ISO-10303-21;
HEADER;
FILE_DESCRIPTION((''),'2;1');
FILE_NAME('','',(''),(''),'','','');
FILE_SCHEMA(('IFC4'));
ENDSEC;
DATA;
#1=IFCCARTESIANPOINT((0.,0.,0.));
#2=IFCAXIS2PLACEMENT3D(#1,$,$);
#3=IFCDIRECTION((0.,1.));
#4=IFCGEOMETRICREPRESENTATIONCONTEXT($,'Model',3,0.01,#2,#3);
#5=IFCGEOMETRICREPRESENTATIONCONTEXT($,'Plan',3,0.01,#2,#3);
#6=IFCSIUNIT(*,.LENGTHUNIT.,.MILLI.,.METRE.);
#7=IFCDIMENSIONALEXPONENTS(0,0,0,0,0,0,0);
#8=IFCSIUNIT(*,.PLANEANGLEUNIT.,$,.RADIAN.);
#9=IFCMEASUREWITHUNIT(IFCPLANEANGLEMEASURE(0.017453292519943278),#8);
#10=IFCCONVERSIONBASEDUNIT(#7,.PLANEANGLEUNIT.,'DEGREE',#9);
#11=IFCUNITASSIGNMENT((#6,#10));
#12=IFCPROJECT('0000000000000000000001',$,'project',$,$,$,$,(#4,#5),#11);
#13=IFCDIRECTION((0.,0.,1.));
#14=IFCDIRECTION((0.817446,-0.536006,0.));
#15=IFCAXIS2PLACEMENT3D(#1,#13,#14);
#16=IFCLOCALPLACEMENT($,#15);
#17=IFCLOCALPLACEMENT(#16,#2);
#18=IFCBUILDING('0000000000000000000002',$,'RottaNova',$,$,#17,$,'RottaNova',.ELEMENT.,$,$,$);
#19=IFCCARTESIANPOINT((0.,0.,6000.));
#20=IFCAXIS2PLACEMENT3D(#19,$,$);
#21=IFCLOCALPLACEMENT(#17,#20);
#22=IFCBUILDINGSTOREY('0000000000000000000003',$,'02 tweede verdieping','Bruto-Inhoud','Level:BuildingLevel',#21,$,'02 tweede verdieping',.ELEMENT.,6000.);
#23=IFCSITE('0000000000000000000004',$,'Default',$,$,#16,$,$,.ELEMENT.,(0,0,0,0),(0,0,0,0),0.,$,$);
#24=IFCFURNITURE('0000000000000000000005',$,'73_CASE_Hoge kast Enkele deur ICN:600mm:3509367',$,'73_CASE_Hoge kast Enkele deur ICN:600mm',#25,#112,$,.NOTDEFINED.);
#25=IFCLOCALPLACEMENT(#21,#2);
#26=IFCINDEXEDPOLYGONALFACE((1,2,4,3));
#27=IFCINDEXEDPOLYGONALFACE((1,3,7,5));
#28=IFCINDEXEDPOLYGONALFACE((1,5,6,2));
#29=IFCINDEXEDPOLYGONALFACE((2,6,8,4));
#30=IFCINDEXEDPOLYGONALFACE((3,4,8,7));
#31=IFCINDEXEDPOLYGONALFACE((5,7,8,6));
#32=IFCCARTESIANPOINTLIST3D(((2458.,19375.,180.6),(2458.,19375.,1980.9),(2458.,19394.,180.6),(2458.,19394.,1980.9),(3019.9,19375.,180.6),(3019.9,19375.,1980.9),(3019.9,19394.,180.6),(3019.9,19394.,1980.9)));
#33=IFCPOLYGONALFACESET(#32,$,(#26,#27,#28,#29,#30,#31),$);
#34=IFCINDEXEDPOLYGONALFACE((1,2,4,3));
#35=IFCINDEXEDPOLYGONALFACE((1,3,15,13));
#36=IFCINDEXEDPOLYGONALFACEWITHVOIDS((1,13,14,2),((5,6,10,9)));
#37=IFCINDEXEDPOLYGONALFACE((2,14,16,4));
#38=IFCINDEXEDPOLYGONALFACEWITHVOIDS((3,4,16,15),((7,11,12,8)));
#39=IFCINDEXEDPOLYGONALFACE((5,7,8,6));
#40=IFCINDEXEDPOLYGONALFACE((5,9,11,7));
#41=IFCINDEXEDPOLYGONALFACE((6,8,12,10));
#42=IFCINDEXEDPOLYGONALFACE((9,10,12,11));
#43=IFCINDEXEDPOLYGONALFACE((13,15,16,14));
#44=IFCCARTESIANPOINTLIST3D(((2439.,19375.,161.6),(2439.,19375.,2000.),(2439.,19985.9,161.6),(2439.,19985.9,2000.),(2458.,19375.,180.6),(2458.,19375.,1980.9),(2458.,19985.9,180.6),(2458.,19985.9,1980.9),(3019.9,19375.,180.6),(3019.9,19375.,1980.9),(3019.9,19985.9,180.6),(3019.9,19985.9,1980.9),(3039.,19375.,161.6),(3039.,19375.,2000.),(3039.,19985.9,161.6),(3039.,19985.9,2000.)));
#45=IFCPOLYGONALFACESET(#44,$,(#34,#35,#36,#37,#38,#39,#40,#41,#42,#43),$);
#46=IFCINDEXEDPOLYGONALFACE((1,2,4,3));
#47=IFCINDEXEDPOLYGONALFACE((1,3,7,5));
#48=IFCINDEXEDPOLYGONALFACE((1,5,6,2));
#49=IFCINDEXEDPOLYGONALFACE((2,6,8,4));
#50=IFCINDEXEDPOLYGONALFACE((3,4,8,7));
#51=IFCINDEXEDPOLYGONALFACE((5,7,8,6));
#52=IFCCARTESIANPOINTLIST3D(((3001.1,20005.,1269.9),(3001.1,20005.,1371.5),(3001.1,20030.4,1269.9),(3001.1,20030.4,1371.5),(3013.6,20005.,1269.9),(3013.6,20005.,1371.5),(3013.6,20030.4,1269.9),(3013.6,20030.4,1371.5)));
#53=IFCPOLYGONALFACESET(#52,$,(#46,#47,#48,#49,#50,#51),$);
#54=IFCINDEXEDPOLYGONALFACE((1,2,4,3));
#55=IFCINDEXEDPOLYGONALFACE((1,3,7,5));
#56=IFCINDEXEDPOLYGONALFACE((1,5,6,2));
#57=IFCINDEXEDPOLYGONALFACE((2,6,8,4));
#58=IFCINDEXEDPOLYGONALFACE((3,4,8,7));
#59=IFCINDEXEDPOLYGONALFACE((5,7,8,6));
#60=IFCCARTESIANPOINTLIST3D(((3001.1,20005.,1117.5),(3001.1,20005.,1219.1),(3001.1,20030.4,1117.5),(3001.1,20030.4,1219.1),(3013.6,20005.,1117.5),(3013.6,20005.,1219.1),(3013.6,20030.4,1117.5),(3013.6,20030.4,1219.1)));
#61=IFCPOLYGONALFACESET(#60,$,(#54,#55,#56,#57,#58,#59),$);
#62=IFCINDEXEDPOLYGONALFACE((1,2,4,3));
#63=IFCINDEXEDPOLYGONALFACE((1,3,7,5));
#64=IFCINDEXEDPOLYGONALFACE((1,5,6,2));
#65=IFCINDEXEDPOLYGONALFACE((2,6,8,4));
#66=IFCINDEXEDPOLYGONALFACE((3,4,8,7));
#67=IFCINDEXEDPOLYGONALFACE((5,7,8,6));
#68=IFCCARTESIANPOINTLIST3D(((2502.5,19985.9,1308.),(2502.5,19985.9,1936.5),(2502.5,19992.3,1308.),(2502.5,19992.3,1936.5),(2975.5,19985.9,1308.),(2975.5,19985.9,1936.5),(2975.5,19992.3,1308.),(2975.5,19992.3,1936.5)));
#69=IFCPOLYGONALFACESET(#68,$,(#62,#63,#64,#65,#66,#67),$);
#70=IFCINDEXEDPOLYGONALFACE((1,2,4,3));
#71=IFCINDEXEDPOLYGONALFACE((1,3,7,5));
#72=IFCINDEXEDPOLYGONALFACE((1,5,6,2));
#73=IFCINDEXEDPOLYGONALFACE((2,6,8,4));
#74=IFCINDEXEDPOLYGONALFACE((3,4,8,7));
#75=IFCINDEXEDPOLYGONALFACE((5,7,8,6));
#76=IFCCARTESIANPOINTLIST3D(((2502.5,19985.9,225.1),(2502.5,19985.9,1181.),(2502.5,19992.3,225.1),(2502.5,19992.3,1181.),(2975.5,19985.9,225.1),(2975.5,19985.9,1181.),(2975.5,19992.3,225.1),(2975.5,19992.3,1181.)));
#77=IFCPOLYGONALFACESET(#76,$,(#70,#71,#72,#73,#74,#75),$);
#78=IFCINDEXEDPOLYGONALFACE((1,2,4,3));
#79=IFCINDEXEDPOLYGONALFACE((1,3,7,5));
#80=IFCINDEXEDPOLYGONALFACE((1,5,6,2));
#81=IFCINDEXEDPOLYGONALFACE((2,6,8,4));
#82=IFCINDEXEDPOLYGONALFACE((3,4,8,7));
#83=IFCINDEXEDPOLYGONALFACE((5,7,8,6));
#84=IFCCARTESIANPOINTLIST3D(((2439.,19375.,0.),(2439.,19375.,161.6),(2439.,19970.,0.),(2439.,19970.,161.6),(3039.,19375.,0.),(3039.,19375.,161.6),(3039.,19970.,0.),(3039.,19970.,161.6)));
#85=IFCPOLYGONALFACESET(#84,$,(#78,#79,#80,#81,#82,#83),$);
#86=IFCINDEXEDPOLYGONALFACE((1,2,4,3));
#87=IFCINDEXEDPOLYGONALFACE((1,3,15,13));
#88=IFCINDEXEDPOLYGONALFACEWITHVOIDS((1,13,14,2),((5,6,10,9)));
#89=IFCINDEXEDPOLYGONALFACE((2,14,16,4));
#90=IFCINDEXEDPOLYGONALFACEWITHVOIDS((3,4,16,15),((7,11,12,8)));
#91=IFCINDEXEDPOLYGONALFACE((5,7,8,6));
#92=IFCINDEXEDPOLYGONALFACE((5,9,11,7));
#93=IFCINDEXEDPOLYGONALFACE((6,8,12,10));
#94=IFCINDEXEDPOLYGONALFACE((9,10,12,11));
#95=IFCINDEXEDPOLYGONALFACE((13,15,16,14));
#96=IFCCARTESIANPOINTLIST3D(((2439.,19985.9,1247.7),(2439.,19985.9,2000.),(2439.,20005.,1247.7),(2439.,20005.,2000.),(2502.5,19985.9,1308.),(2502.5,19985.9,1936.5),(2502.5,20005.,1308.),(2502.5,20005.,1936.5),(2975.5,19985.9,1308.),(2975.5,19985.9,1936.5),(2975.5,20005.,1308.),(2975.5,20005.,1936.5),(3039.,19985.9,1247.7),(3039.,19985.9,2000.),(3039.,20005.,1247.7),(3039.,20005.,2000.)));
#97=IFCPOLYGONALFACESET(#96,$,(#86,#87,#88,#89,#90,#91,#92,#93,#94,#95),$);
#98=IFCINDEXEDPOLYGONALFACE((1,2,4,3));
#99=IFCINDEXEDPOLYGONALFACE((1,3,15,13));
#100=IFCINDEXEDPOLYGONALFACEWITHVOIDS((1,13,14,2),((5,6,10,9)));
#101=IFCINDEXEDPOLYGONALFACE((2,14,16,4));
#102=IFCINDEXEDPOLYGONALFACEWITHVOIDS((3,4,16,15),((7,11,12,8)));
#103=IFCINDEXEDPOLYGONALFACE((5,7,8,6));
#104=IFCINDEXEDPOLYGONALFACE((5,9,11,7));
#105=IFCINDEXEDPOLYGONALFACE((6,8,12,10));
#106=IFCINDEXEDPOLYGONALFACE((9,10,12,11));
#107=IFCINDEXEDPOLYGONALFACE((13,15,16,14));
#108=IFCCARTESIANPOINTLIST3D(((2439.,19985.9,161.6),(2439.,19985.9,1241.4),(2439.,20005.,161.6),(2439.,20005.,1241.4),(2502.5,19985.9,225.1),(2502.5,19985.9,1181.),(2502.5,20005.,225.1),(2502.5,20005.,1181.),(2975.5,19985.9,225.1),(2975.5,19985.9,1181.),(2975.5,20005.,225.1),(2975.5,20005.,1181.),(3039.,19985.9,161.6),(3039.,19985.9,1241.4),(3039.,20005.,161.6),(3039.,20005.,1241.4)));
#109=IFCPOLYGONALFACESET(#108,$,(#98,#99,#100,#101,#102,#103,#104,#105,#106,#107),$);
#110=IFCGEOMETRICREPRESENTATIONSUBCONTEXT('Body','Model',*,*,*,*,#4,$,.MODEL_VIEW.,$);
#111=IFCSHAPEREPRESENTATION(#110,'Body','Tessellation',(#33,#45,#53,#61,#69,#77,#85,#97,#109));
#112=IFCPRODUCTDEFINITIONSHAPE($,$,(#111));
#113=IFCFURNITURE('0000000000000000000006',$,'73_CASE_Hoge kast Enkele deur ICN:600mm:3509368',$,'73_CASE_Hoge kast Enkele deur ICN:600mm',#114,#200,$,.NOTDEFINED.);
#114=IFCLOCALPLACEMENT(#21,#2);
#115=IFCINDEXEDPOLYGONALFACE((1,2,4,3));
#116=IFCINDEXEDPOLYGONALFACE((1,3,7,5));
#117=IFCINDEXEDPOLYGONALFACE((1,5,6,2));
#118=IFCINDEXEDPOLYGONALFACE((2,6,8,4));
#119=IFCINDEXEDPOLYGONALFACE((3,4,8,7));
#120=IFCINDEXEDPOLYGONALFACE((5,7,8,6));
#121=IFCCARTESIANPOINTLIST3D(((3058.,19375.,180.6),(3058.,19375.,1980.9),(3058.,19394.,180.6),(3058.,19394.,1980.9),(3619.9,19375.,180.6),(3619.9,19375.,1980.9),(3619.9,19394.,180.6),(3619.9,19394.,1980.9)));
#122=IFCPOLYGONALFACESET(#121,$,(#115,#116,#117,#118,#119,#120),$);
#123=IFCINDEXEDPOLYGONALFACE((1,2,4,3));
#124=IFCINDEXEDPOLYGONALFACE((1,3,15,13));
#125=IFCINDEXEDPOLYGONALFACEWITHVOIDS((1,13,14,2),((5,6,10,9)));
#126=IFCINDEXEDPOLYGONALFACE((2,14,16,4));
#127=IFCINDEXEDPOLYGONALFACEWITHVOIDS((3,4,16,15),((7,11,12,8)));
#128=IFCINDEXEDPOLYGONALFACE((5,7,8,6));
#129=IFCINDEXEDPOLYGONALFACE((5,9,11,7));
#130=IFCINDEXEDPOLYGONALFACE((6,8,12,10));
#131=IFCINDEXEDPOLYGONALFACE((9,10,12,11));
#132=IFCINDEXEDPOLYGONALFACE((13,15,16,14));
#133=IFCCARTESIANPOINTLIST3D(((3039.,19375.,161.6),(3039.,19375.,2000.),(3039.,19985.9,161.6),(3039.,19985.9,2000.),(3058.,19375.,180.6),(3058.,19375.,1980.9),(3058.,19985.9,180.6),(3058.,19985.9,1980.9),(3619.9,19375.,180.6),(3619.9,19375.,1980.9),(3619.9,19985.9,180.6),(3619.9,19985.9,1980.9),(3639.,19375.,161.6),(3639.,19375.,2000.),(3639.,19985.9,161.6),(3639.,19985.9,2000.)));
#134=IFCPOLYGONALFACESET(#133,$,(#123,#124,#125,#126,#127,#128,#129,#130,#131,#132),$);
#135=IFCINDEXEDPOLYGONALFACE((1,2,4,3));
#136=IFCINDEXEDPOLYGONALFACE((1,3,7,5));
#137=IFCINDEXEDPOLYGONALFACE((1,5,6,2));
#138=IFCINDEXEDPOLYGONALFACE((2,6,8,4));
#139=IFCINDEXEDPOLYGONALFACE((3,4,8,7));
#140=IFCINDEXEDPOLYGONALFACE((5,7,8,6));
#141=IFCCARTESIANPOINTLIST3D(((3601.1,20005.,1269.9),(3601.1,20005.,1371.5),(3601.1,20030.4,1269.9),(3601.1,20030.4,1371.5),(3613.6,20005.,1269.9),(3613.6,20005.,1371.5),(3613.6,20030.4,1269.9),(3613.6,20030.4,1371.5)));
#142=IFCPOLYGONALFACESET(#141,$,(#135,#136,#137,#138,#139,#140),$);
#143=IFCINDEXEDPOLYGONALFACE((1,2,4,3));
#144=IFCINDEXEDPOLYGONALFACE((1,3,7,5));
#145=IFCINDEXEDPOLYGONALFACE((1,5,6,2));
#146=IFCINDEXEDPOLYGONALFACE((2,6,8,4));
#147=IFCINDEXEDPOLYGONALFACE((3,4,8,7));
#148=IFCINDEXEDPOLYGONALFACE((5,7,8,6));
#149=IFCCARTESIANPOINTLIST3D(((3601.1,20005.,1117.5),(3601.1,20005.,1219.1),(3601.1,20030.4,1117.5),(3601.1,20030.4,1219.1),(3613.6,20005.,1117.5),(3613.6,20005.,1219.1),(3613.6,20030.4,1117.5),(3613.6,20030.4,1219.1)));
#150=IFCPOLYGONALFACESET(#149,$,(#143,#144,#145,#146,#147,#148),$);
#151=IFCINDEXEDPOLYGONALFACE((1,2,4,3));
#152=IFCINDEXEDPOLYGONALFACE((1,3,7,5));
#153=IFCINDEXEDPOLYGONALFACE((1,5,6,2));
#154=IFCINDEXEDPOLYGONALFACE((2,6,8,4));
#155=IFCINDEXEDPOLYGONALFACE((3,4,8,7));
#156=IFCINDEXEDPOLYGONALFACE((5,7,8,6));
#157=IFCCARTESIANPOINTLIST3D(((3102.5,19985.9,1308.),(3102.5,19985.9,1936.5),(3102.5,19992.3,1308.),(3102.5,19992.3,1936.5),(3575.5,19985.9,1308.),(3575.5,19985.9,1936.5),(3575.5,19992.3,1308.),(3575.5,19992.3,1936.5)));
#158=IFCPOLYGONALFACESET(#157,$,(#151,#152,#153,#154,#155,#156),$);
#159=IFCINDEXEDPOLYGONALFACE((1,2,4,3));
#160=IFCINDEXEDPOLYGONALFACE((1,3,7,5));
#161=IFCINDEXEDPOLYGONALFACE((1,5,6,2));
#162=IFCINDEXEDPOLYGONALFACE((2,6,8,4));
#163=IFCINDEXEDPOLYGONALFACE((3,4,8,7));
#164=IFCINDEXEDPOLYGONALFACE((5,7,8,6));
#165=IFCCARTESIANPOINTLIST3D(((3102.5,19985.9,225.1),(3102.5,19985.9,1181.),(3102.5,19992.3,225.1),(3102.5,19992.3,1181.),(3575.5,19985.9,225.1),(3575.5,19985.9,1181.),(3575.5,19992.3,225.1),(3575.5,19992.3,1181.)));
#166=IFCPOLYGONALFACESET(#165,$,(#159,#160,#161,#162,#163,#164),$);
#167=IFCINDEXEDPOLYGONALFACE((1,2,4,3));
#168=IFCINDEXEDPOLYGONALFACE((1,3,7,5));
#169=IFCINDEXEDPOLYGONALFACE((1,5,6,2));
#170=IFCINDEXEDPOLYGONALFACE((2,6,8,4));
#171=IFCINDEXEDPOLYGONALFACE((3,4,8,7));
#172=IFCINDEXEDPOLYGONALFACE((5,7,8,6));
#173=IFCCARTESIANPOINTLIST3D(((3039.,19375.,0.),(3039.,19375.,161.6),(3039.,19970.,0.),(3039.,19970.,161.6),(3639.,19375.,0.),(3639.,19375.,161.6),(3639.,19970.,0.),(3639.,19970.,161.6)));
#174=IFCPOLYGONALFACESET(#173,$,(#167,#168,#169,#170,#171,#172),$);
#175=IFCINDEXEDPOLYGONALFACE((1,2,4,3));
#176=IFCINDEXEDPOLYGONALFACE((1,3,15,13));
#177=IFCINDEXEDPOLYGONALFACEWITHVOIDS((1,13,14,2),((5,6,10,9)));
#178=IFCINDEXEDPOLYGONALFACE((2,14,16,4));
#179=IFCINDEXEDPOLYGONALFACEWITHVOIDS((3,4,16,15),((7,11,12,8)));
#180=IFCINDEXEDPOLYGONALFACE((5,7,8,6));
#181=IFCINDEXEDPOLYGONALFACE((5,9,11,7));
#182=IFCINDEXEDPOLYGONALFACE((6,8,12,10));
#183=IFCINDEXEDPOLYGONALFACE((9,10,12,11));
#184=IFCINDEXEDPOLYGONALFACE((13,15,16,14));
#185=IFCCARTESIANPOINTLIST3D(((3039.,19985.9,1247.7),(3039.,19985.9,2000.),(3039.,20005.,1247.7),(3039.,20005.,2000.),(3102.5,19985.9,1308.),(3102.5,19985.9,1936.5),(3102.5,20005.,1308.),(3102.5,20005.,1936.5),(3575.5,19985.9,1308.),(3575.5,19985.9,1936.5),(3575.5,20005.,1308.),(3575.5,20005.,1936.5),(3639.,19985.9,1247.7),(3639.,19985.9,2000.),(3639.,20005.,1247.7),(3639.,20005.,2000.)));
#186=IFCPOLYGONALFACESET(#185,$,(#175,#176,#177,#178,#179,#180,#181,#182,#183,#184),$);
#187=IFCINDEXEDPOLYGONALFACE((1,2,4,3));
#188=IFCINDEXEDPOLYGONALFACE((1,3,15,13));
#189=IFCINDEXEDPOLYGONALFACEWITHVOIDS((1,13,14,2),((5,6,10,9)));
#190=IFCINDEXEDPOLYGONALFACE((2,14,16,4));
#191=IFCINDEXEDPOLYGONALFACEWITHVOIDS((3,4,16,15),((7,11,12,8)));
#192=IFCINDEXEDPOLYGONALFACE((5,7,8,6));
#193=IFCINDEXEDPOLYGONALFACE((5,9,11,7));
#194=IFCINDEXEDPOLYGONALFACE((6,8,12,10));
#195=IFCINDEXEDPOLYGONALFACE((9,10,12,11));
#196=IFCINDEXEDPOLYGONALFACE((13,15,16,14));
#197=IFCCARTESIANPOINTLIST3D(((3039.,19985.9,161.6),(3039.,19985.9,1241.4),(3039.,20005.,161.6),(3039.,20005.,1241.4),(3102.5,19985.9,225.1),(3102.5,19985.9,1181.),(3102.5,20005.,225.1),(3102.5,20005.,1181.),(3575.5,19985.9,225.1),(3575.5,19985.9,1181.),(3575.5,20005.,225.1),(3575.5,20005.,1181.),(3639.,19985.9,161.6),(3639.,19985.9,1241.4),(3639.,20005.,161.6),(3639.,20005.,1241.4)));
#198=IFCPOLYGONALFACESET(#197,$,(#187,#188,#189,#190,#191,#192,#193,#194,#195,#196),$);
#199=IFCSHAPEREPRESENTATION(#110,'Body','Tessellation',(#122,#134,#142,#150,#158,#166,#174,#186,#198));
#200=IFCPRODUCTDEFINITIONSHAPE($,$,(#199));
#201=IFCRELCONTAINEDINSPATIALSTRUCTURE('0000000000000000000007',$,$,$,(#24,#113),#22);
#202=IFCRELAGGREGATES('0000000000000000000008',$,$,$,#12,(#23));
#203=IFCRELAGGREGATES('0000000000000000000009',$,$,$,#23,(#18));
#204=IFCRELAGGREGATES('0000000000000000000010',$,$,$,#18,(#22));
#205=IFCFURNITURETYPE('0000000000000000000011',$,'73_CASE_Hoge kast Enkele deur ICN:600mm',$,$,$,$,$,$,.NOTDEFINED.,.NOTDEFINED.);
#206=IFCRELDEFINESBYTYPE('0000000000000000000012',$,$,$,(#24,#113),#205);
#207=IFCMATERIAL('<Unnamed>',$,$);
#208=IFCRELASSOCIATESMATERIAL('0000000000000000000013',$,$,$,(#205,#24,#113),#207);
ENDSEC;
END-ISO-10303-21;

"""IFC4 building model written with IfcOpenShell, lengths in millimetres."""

from ifc_helpers import new_model, entity, si_unit, converted_unit, direction, frame, origin, place, context, subcontext, project, spatial, indexed_curve, outline, extrude, source, transform, mapped, material, type_object, type_shapes, element, save


model = new_model("IFC4")

# Units and contexts
model_context = context("Model", 3, precision=0.01, world=origin(), true_north=direction((0.0, 1.0)))
plan_context = context("Plan", 3, precision=0.01, world=origin(), true_north=direction((0.0, 1.0)))
body_context = subcontext(model_context, "Body", "Model", "MODEL_VIEW")
ifc_project = project(units=[si_unit("LENGTHUNIT", "METRE", prefix="MILLI"), converted_unit("PLANEANGLEUNIT", "DEGREE", entity("IfcPlaneAngleMeasure", 0.017453292519943278), si_unit("PLANEANGLEUNIT", "RADIAN"), dimensions=[0, 0, 0, 0, 0, 0, 0])], contexts=[model_context, plan_context])

# Site, building, storey
site_placement = place(None, frame((0.0, 0.0, 0.0), z_axis=(0.0, 0.0, 1.0), x_axis=(0.817446, -0.536006, 0.0)))
site = spatial("IfcSite", under=ifc_project, at=site_placement, Name="Default", CompositionType="ELEMENT", RefLatitude=(0, 0, 0, 0), RefLongitude=(0, 0, 0, 0), RefElevation=0.0)
building_placement = place(site_placement, origin())
building = spatial("IfcBuilding", under=site, at=building_placement, Name="RottaNova", LongName="RottaNova", CompositionType="ELEMENT")
storey_placement = place(building_placement, frame((0.0, 0.0, 6000.0)))
storey = spatial("IfcBuildingStorey", under=building, at=storey_placement, Name="02 tweede verdieping", Description="Bruto-Inhoud", ObjectType="Level:BuildingLevel", LongName="02 tweede verdieping", CompositionType="ELEMENT", Elevation=6000.0)

# Furniture
ifc_material_1 = material(Name="<Unnamed>")
furniture_type = type_object("IfcFurnitureType", Name="73_CASE_Hoge kast Enkele deur ICN:600mm", AssemblyPlace="NOTDEFINED", PredefinedType="NOTDEFINED", material=ifc_material_1)
shared_shape_1 = source(origin(), body_context, "Body", "SweptSolid", [
    extrude(outline(indexed_curve([(-280.9, -9.5), (280.9, -9.5), (280.9, 9.5), (-280.9, 9.5), (-280.9, -9.5)], self_intersect=False)), frame((18.7, 9.5, 180.6), z_axis=(0.0, 0.0, 1.0), x_axis=(-1.0, 0.0, 0.0)), (0.0, 0.0, 1.0), 1800.3),
    extrude(outline(indexed_curve([(-300.0, -919.2), (300.0, -919.2), (300.0, 919.2), (-300.0, 919.2), (-300.0, -919.2)], self_intersect=False), holes=[indexed_curve([(-280.9, 900.2), (281.0, 900.2), (281.0, -900.2), (-280.9, -900.2), (-280.9, 900.2)], self_intersect=False)]), frame((18.7, 0.0, 1080.8), z_axis=(0.0, 1.0, 0.0), x_axis=(-1.0, 0.0, 0.0)), (0.0, 0.0, 1.0), 610.9),
    extrude(outline(indexed_curve([(-6.3, -12.7), (6.3, -12.7), (6.3, 12.7), (-6.3, 12.7), (-6.3, -12.7)], self_intersect=False)), frame((287.1, 642.7, 1269.9), z_axis=(0.0, 0.0, 1.0), x_axis=(-1.0, 0.0, 0.0)), (0.0, 0.0, 1.0), 101.6),
    extrude(outline(indexed_curve([(-6.3, -12.7), (6.3, -12.7), (6.3, 12.7), (-6.3, 12.7), (-6.3, -12.7)], self_intersect=False)), frame((287.1, 642.7, 1117.5), z_axis=(0.0, 0.0, 1.0), x_axis=(-1.0, 0.0, 0.0)), (0.0, 0.0, 1.0), 101.6),
    extrude(outline(indexed_curve([(-236.5, -3.2), (236.5, -3.2), (236.5, 3.2), (-236.5, 3.2), (-236.5, -3.2)], self_intersect=False)), frame((18.7, 614.1, 1308.0), z_axis=(0.0, 0.0, 1.0), x_axis=(-1.0, 0.0, 0.0)), (0.0, 0.0, 1.0), 628.5),
    extrude(outline(indexed_curve([(-236.5, -3.2), (236.5, -3.2), (236.5, 3.2), (-236.5, 3.2), (-236.5, -3.2)], self_intersect=False)), frame((18.7, 614.1, 225.1), z_axis=(0.0, 0.0, 1.0), x_axis=(-1.0, 0.0, 0.0)), (0.0, 0.0, 1.0), 956.0),
    extrude(outline(indexed_curve([(-297.5, -300.0), (297.5, -300.0), (297.5, 300.0), (-297.5, 300.0), (-297.5, -300.0)], self_intersect=False)), frame((18.7, 297.5, 0.0), z_axis=(0.0, 0.0, 1.0), x_axis=(0.0, 1.0, 0.0)), (0.0, 0.0, 1.0), 161.6),
    extrude(outline(indexed_curve([(-376.1, -300.0), (376.1, -300.0), (376.1, 300.0), (-376.1, 300.0), (-376.1, -300.0)], self_intersect=False), holes=[indexed_curve([(-312.6, -236.5), (-312.6, 236.5), (315.8, 236.5), (315.8, -236.5), (-312.6, -236.5)], self_intersect=False)]), frame((18.7, 610.9, 1623.9), z_axis=(0.0, 1.0, 0.0), x_axis=(0.0, 0.0, -1.0)), (0.0, 0.0, 1.0), 19.1),
    extrude(outline(indexed_curve([(-300.0, -539.9), (300.0, -539.9), (300.0, 539.9), (-300.0, 539.9), (-300.0, -539.9)], self_intersect=False), holes=[indexed_curve([(-236.5, 479.6), (236.5, 479.6), (236.5, -476.4), (-236.5, -476.4), (-236.5, 479.6)], self_intersect=False)]), frame((18.7, 610.9, 701.5), z_axis=(0.0, 1.0, 0.0), x_axis=(-1.0, 0.0, 0.0)), (0.0, 0.0, 1.0), 19.1),
])
type_shapes(furniture_type, [shared_shape_1])
for number, where, name in (
    (1, (2720.3, 19375.0, 0.0), "73_CASE_Hoge kast Enkele deur ICN:600mm:3509367"),
    (2, (3320.3, 19375.0, 0.0), "73_CASE_Hoge kast Enkele deur ICN:600mm:3509368"),
):
    element("IfcFurniture", number, at=place(storey_placement, frame(where)), inside=storey, type_object=furniture_type, material=ifc_material_1, Name=name, ObjectType="73_CASE_Hoge kast Enkele deur ICN:600mm", PredefinedType="NOTDEFINED", context=body_context, shape_type="MappedRepresentation", body=[
        mapped(shared_shape_1, transform((0.0, 0.0, 0.0), scale=1.0)),
    ])

save(model, "model.ifc")
